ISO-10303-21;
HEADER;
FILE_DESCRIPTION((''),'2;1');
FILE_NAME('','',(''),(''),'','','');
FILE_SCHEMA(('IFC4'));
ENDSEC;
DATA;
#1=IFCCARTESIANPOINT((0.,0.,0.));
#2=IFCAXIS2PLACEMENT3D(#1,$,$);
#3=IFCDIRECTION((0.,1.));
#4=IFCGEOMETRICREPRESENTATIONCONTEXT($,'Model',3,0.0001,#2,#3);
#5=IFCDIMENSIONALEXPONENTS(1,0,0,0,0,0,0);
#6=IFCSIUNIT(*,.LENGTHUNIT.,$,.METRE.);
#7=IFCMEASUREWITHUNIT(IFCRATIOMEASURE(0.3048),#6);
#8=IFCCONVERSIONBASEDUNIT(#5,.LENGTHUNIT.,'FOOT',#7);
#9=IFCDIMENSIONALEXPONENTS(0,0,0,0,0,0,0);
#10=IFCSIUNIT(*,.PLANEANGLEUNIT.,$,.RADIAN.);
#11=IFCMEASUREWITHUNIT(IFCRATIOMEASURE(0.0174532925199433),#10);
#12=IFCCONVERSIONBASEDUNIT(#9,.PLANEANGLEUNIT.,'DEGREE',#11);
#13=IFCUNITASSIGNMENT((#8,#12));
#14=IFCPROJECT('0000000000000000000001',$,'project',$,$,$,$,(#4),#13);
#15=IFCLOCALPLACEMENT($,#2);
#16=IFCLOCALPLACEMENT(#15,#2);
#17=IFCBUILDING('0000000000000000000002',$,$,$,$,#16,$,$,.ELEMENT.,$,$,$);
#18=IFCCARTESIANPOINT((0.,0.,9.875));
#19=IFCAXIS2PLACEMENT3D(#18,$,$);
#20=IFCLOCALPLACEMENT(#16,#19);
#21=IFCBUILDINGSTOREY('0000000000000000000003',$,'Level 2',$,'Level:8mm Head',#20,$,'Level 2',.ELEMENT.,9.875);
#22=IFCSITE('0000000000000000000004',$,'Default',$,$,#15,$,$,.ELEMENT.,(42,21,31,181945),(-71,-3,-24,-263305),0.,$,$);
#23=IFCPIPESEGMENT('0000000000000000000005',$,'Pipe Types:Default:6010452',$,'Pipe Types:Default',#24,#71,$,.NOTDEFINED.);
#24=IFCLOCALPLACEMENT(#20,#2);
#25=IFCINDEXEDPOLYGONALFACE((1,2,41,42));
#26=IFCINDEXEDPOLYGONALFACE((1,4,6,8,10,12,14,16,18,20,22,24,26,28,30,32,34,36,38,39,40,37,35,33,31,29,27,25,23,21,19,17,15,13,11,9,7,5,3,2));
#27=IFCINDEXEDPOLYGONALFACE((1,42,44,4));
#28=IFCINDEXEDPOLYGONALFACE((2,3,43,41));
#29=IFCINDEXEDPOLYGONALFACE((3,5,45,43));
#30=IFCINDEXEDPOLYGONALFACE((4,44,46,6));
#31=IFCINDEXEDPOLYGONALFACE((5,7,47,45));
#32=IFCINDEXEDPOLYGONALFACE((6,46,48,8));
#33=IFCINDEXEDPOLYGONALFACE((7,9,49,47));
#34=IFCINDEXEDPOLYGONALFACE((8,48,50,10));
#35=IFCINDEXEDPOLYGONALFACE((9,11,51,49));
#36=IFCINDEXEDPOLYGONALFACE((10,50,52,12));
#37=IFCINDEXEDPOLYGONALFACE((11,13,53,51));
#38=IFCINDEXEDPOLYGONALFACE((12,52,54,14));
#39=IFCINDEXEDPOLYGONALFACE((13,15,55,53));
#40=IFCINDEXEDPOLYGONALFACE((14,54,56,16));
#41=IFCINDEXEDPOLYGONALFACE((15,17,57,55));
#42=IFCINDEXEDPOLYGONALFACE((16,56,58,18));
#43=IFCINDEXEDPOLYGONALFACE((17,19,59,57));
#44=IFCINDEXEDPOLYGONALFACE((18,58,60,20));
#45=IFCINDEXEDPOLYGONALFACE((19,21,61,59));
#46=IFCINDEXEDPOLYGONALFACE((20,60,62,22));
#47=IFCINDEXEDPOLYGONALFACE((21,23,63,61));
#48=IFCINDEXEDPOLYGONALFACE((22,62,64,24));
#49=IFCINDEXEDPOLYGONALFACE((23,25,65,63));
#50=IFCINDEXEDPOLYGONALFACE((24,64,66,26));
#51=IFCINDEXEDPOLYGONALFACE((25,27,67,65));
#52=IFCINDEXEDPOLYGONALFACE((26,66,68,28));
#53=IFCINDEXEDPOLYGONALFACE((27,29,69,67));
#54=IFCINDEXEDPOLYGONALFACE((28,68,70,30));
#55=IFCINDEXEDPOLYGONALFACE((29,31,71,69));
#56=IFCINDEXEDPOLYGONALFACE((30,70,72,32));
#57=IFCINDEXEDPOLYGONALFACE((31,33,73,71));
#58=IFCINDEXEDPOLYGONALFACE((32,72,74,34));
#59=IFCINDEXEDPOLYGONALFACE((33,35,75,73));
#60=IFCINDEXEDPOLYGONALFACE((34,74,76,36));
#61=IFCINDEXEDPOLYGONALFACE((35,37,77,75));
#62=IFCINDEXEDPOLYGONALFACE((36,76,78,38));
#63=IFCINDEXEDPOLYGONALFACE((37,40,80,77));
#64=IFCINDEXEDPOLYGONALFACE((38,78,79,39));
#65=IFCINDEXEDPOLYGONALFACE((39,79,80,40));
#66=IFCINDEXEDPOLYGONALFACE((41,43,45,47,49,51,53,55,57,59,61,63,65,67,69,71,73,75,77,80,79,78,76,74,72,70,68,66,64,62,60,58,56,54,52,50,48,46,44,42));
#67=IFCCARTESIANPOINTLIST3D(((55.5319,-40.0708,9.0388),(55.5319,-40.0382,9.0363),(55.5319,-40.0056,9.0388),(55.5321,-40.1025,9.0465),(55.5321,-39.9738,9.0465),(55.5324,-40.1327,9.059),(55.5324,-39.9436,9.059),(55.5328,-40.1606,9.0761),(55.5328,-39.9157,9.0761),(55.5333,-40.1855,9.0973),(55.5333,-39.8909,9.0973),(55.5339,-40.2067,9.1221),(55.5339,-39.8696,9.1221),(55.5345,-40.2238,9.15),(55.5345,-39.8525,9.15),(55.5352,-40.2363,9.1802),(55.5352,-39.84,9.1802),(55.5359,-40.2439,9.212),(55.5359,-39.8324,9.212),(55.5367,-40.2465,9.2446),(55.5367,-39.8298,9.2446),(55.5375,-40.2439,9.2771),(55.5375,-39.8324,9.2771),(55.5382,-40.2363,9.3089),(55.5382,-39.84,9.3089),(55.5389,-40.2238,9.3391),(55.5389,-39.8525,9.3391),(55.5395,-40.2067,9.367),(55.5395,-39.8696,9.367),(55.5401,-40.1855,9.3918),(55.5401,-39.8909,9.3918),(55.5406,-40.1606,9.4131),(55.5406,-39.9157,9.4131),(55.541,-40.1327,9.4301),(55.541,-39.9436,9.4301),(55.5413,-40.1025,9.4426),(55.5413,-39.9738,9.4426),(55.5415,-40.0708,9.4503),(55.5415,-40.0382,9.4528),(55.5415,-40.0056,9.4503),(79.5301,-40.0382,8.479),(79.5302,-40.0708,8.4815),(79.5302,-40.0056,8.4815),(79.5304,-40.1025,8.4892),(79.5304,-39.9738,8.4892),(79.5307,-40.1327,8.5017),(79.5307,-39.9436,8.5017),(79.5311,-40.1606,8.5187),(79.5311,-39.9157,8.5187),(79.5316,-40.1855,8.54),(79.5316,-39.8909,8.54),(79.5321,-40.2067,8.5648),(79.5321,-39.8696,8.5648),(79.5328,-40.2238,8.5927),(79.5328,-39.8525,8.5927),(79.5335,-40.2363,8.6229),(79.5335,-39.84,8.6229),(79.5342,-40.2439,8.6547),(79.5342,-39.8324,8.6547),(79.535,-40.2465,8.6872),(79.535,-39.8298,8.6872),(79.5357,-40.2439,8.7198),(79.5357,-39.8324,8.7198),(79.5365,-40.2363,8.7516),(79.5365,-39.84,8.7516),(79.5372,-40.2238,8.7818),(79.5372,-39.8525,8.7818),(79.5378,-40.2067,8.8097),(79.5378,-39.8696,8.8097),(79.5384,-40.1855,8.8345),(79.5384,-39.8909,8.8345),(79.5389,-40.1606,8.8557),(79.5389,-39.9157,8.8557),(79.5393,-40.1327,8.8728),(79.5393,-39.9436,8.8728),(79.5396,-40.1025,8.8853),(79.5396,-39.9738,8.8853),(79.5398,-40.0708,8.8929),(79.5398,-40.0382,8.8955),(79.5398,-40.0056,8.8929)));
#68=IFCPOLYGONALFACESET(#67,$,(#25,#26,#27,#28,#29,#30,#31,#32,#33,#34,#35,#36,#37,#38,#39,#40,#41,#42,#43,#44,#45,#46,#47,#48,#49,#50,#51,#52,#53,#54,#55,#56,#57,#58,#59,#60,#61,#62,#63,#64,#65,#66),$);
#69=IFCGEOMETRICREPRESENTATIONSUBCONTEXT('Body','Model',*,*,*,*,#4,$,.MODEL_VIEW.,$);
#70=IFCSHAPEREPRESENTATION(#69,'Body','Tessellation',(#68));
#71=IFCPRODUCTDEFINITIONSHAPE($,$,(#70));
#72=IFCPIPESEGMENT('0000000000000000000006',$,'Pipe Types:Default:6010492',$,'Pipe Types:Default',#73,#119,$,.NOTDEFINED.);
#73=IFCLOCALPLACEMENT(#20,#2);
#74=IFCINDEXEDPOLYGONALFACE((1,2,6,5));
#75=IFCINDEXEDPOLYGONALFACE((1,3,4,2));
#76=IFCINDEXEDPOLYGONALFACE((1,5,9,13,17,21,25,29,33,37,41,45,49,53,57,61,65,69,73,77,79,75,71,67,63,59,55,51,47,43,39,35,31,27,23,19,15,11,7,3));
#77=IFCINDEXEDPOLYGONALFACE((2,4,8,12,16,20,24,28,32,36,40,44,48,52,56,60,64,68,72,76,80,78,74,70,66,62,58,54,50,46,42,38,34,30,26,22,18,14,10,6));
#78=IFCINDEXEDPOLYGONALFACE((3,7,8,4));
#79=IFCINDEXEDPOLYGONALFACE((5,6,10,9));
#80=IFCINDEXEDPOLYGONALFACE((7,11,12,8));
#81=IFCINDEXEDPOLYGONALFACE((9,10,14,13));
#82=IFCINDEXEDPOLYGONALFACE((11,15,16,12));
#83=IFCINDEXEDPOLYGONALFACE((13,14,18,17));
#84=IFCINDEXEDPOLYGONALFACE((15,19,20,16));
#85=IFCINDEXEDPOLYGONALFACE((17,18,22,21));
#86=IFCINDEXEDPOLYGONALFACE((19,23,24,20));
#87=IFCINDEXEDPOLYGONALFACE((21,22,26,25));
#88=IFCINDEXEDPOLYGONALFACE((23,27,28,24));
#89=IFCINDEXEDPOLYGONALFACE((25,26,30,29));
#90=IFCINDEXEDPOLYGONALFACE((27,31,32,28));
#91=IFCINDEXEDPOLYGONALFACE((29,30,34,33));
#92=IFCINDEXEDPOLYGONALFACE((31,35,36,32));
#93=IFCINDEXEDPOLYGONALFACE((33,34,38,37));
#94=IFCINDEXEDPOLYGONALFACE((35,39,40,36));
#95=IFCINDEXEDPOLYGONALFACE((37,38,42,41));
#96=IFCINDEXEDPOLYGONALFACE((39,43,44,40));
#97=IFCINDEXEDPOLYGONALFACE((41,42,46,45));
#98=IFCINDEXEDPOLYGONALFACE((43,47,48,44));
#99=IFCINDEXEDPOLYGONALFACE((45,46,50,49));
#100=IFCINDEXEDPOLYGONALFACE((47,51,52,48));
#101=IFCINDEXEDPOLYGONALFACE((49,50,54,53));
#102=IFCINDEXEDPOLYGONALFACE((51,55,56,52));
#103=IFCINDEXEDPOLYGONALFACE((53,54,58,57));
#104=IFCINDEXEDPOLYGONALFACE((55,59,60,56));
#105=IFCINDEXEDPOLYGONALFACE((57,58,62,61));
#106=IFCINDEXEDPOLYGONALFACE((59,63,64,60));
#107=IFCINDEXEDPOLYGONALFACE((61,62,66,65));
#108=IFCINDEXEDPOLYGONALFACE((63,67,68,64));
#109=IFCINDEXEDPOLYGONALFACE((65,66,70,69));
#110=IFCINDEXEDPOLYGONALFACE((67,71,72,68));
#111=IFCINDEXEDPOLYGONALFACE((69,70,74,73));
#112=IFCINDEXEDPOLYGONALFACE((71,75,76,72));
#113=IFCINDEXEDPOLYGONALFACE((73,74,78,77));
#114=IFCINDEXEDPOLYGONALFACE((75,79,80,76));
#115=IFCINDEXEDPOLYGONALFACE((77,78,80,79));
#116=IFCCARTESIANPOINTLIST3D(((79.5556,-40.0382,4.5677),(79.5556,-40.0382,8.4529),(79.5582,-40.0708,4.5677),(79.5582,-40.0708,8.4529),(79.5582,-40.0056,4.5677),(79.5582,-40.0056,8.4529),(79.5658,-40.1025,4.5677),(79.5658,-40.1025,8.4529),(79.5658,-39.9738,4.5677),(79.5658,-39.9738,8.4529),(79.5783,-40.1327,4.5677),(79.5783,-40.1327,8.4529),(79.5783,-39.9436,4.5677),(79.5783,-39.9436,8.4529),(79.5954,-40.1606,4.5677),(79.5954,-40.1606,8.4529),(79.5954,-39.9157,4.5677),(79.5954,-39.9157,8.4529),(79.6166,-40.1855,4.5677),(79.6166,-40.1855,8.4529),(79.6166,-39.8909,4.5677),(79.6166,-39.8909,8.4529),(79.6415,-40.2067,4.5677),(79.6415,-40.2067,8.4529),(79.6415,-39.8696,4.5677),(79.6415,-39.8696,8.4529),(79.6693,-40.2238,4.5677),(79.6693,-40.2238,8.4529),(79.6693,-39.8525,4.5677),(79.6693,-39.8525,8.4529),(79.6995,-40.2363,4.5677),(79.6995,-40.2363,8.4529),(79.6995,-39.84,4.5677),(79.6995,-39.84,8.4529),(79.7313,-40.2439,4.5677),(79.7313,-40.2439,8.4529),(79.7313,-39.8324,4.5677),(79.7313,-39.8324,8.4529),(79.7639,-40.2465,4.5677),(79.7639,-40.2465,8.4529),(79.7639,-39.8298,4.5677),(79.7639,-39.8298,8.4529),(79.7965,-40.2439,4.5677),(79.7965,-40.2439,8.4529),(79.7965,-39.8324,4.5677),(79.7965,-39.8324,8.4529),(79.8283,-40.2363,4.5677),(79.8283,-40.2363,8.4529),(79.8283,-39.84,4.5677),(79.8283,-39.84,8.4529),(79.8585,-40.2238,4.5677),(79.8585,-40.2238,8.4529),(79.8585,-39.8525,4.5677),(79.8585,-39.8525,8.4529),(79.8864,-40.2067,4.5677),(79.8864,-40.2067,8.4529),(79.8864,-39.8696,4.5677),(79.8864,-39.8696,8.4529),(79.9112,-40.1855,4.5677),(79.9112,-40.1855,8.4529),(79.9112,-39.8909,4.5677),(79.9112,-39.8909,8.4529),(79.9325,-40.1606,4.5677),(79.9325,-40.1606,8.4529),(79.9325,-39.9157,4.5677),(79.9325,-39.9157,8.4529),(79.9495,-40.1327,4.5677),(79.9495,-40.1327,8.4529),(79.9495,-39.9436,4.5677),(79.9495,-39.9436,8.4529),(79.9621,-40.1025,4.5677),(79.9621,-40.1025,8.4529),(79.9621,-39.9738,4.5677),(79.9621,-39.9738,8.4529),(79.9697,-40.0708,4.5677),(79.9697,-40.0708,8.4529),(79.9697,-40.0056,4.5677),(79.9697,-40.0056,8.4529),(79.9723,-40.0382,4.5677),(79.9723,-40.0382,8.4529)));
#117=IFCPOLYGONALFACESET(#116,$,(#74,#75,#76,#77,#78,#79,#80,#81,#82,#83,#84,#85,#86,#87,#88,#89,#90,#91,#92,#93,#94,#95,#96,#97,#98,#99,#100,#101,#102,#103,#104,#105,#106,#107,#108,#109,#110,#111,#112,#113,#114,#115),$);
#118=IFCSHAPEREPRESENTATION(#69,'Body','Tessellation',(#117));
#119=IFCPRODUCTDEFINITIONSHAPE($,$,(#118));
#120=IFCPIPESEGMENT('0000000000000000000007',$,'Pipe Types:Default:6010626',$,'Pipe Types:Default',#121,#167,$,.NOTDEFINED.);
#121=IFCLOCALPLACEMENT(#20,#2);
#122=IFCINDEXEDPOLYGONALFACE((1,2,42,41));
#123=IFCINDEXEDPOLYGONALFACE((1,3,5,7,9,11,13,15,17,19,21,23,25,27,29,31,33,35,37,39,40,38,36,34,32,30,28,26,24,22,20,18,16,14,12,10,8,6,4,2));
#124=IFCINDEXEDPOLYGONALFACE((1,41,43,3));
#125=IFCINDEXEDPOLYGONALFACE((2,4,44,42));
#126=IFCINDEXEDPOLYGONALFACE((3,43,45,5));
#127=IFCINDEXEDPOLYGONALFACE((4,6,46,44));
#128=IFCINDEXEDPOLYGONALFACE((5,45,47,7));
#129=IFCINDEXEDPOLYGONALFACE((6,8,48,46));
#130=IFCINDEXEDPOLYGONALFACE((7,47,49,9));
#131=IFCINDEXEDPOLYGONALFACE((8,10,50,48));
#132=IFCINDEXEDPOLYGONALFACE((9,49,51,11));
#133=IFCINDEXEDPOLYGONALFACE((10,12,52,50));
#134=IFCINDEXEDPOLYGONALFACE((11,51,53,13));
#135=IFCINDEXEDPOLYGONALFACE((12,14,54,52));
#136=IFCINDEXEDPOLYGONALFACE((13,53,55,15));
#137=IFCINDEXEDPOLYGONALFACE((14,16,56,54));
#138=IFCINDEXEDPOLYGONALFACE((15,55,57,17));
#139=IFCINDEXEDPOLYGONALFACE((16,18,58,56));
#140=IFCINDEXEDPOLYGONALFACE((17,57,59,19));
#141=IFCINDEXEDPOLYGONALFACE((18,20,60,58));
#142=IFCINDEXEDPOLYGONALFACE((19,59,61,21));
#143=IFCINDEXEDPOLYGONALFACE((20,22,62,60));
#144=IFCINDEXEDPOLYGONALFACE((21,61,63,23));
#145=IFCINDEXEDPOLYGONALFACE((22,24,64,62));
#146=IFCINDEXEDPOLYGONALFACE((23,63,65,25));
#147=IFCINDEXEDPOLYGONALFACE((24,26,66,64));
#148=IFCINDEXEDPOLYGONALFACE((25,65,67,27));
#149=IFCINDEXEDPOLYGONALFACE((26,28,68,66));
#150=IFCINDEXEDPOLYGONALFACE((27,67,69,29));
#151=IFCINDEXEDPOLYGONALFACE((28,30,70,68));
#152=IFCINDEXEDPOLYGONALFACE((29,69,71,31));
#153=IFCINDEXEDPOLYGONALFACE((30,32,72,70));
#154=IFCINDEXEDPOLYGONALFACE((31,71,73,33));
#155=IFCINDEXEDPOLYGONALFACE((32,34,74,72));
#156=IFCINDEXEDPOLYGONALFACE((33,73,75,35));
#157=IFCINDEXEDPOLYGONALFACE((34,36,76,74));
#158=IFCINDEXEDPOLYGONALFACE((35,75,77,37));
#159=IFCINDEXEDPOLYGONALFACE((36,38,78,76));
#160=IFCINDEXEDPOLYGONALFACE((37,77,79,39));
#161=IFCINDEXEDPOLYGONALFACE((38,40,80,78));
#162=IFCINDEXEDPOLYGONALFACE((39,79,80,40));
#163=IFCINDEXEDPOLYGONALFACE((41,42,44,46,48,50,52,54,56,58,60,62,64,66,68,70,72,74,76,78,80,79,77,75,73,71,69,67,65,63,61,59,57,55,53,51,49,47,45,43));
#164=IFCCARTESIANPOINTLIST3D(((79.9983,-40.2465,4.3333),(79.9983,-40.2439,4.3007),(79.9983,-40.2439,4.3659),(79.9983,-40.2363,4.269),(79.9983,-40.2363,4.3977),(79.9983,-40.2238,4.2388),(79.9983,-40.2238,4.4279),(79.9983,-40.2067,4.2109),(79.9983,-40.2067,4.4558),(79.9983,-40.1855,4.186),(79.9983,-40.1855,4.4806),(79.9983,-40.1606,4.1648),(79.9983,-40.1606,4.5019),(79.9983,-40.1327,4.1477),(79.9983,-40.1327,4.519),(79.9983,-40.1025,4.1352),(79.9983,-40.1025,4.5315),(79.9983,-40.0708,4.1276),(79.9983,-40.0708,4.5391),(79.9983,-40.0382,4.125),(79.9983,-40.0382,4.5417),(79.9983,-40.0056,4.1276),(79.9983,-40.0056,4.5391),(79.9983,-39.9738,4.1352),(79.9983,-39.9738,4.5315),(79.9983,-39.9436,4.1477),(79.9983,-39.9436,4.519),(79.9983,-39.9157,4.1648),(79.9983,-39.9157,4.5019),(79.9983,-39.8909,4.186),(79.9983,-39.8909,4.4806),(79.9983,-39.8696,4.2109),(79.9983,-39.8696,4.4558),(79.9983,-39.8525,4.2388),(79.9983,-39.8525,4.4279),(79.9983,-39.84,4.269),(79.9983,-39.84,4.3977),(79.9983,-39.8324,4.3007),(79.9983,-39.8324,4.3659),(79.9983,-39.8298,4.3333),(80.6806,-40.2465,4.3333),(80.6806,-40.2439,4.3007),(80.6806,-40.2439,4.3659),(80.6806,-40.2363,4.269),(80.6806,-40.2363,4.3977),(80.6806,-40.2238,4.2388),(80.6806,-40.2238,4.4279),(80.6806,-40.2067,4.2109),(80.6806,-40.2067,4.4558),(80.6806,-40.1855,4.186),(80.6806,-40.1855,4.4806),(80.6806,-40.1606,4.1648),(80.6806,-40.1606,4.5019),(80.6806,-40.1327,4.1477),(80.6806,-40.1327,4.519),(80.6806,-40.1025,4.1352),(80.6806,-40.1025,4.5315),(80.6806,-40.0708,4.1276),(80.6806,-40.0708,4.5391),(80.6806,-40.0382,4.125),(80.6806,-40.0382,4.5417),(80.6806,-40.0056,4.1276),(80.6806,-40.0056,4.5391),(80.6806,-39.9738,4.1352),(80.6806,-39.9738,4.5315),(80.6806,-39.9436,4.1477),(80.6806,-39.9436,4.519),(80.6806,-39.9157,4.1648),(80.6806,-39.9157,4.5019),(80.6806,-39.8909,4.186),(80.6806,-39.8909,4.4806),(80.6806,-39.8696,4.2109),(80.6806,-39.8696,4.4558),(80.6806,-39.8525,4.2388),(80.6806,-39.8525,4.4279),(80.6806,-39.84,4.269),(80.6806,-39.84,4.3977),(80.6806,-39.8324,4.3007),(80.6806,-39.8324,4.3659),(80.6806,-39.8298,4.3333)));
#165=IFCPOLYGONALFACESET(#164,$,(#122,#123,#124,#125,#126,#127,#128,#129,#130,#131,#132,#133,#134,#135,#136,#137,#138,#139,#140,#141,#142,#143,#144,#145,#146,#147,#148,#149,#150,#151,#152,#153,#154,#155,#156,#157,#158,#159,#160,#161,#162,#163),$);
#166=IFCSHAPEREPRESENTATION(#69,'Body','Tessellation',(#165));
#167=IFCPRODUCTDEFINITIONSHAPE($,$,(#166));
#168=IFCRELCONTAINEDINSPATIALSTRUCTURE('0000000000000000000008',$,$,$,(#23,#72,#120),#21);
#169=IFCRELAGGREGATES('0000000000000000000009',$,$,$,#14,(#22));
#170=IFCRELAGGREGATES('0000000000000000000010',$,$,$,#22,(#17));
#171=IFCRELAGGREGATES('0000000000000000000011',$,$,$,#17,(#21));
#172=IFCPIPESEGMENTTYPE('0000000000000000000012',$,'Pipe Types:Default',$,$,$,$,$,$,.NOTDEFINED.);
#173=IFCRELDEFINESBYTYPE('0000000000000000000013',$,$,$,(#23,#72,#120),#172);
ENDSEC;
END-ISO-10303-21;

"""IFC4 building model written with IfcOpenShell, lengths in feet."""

from ifc_helpers import new_model, entity, si_unit, converted_unit, direction, frame, origin, place, context, subcontext, project, spatial, indexed_curve, outline, extrude, type_object, element, save


model = new_model("IFC4")

# Units and contexts
model_context = context("Model", 3, precision=0.0001, world=origin(), true_north=direction((0.0, 1.0)))
body_context = subcontext(model_context, "Body", "Model", "MODEL_VIEW")
ifc_project = project(units=[converted_unit("LENGTHUNIT", "FOOT", entity("IfcRatioMeasure", 0.3048), si_unit("LENGTHUNIT", "METRE"), dimensions=[1, 0, 0, 0, 0, 0, 0]), converted_unit("PLANEANGLEUNIT", "DEGREE", entity("IfcRatioMeasure", 0.0174532925199433), si_unit("PLANEANGLEUNIT", "RADIAN"), dimensions=[0, 0, 0, 0, 0, 0, 0])], contexts=[model_context])

# Site, building, storey
site_placement = place(None, origin())
site = spatial("IfcSite", under=ifc_project, at=site_placement, Name="Default", CompositionType="ELEMENT", RefLatitude=(42, 21, 31, 181945), RefLongitude=(-71, -3, -24, -263305), RefElevation=0.0)
building_placement = place(site_placement, origin())
building = spatial("IfcBuilding", under=site, at=building_placement, CompositionType="ELEMENT")
storey_placement = place(building_placement, frame((0.0, 0.0, 9.875)))
storey = spatial("IfcBuildingStorey", under=building, at=storey_placement, Name="Level 2", ObjectType="Level:8mm Head", LongName="Level 2", CompositionType="ELEMENT", Elevation=9.875)

# Pipe segments
pipe_segment_type = type_object("IfcPipeSegmentType", Name="Pipe Types:Default", PredefinedType="NOTDEFINED")
pipe_segment_1_placement = place(storey_placement, origin())
element("IfcPipeSegment", 1, at=pipe_segment_1_placement, inside=storey, type_object=pipe_segment_type, Name="Pipe Types:Default:6010452", ObjectType="Pipe Types:Default", PredefinedType="NOTDEFINED", context=body_context, shape_type="SweptSolid", body=[
    extrude(outline(indexed_curve([(0.2083, 0.0), (0.2058, 0.0326), (0.1981, 0.0644), (0.1856, 0.0946), (0.1685, 0.1225), (0.1473, 0.1473), (0.1225, 0.1685), (0.0946, 0.1856), (0.0644, 0.1981), (0.0326, 0.2058), (0.0, 0.2083), (-0.0326, 0.2058), (-0.0644, 0.1981), (-0.0946, 0.1856), (-0.1225, 0.1685), (-0.1473, 0.1473), (-0.1685, 0.1225), (-0.1856, 0.0946), (-0.1981, 0.0644), (-0.2058, 0.0326), (-0.2083, 0.0), (-0.2058, -0.0326), (-0.1981, -0.0644), (-0.1856, -0.0946), (-0.1685, -0.1225), (-0.1473, -0.1473), (-0.1225, -0.1685), (-0.0946, -0.1856), (-0.0644, -0.1981), (-0.0326, -0.2058), (0.0, -0.2083), (0.0326, -0.2058), (0.0644, -0.1981), (0.0946, -0.1856), (0.1225, -0.1685), (0.1473, -0.1473), (0.1685, -0.1225), (0.1856, -0.0946), (0.1981, -0.0644), (0.2058, -0.0326), (0.2083, 0.0)], self_intersect=False)), frame((55.5367, -40.0382, 9.2446), z_axis=(0.99973, 0.0, -0.023217), x_axis=(0.0, -1.0, 0.0)), (0.0, 0.0, 1.0), 24.0048),
])
pipe_segment_2_placement = place(storey_placement, origin())
element("IfcPipeSegment", 2, at=pipe_segment_2_placement, inside=storey, type_object=pipe_segment_type, Name="Pipe Types:Default:6010492", ObjectType="Pipe Types:Default", PredefinedType="NOTDEFINED", context=body_context, shape_type="SweptSolid", body=[
    extrude(outline(indexed_curve([(0.2083, 0.0), (0.2058, 0.0326), (0.1981, 0.0644), (0.1856, 0.0946), (0.1685, 0.1225), (0.1473, 0.1473), (0.1225, 0.1685), (0.0946, 0.1856), (0.0644, 0.1981), (0.0326, 0.2058), (0.0, 0.2083), (-0.0326, 0.2058), (-0.0644, 0.1981), (-0.0946, 0.1856), (-0.1225, 0.1685), (-0.1473, 0.1473), (-0.1685, 0.1225), (-0.1856, 0.0946), (-0.1981, 0.0644), (-0.2058, 0.0326), (-0.2083, 0.0), (-0.2058, -0.0326), (-0.1981, -0.0644), (-0.1856, -0.0946), (-0.1685, -0.1225), (-0.1473, -0.1473), (-0.1225, -0.1685), (-0.0946, -0.1856), (-0.0644, -0.1981), (-0.0326, -0.2058), (0.0, -0.2083), (0.0326, -0.2058), (0.0644, -0.1981), (0.0946, -0.1856), (0.1225, -0.1685), (0.1473, -0.1473), (0.1685, -0.1225), (0.1856, -0.0946), (0.1981, -0.0644), (0.2058, -0.0326), (0.2083, 0.0)], self_intersect=False)), frame((79.7639, -40.0382, 4.5677)), (0.0, 0.0, 1.0), 3.8852),
])
pipe_segment_3_placement = place(storey_placement, origin())
element("IfcPipeSegment", 3, at=pipe_segment_3_placement, inside=storey, type_object=pipe_segment_type, Name="Pipe Types:Default:6010626", ObjectType="Pipe Types:Default", PredefinedType="NOTDEFINED", context=body_context, shape_type="SweptSolid", body=[
    extrude(outline(indexed_curve([(0.2083, 0.0), (0.2058, 0.0326), (0.1981, 0.0644), (0.1856, 0.0946), (0.1685, 0.1225), (0.1473, 0.1473), (0.1225, 0.1685), (0.0946, 0.1856), (0.0644, 0.1981), (0.0326, 0.2058), (0.0, 0.2083), (-0.0326, 0.2058), (-0.0644, 0.1981), (-0.0946, 0.1856), (-0.1225, 0.1685), (-0.1473, 0.1473), (-0.1685, 0.1225), (-0.1856, 0.0946), (-0.1981, 0.0644), (-0.2058, 0.0326), (-0.2083, 0.0), (-0.2058, -0.0326), (-0.1981, -0.0644), (-0.1856, -0.0946), (-0.1685, -0.1225), (-0.1473, -0.1473), (-0.1225, -0.1685), (-0.0946, -0.1856), (-0.0644, -0.1981), (-0.0326, -0.2058), (0.0, -0.2083), (0.0326, -0.2058), (0.0644, -0.1981), (0.0946, -0.1856), (0.1225, -0.1685), (0.1473, -0.1473), (0.1685, -0.1225), (0.1856, -0.0946), (0.1981, -0.0644), (0.2058, -0.0326), (0.2083, 0.0)], self_intersect=False)), frame((79.9983, -40.0382, 4.3333), z_axis=(1.0, 0.0, 0.0), x_axis=(0.0, -1.0, 0.0)), (0.0, 0.0, 1.0), 0.6823),
])

save(model, "model.ifc")
